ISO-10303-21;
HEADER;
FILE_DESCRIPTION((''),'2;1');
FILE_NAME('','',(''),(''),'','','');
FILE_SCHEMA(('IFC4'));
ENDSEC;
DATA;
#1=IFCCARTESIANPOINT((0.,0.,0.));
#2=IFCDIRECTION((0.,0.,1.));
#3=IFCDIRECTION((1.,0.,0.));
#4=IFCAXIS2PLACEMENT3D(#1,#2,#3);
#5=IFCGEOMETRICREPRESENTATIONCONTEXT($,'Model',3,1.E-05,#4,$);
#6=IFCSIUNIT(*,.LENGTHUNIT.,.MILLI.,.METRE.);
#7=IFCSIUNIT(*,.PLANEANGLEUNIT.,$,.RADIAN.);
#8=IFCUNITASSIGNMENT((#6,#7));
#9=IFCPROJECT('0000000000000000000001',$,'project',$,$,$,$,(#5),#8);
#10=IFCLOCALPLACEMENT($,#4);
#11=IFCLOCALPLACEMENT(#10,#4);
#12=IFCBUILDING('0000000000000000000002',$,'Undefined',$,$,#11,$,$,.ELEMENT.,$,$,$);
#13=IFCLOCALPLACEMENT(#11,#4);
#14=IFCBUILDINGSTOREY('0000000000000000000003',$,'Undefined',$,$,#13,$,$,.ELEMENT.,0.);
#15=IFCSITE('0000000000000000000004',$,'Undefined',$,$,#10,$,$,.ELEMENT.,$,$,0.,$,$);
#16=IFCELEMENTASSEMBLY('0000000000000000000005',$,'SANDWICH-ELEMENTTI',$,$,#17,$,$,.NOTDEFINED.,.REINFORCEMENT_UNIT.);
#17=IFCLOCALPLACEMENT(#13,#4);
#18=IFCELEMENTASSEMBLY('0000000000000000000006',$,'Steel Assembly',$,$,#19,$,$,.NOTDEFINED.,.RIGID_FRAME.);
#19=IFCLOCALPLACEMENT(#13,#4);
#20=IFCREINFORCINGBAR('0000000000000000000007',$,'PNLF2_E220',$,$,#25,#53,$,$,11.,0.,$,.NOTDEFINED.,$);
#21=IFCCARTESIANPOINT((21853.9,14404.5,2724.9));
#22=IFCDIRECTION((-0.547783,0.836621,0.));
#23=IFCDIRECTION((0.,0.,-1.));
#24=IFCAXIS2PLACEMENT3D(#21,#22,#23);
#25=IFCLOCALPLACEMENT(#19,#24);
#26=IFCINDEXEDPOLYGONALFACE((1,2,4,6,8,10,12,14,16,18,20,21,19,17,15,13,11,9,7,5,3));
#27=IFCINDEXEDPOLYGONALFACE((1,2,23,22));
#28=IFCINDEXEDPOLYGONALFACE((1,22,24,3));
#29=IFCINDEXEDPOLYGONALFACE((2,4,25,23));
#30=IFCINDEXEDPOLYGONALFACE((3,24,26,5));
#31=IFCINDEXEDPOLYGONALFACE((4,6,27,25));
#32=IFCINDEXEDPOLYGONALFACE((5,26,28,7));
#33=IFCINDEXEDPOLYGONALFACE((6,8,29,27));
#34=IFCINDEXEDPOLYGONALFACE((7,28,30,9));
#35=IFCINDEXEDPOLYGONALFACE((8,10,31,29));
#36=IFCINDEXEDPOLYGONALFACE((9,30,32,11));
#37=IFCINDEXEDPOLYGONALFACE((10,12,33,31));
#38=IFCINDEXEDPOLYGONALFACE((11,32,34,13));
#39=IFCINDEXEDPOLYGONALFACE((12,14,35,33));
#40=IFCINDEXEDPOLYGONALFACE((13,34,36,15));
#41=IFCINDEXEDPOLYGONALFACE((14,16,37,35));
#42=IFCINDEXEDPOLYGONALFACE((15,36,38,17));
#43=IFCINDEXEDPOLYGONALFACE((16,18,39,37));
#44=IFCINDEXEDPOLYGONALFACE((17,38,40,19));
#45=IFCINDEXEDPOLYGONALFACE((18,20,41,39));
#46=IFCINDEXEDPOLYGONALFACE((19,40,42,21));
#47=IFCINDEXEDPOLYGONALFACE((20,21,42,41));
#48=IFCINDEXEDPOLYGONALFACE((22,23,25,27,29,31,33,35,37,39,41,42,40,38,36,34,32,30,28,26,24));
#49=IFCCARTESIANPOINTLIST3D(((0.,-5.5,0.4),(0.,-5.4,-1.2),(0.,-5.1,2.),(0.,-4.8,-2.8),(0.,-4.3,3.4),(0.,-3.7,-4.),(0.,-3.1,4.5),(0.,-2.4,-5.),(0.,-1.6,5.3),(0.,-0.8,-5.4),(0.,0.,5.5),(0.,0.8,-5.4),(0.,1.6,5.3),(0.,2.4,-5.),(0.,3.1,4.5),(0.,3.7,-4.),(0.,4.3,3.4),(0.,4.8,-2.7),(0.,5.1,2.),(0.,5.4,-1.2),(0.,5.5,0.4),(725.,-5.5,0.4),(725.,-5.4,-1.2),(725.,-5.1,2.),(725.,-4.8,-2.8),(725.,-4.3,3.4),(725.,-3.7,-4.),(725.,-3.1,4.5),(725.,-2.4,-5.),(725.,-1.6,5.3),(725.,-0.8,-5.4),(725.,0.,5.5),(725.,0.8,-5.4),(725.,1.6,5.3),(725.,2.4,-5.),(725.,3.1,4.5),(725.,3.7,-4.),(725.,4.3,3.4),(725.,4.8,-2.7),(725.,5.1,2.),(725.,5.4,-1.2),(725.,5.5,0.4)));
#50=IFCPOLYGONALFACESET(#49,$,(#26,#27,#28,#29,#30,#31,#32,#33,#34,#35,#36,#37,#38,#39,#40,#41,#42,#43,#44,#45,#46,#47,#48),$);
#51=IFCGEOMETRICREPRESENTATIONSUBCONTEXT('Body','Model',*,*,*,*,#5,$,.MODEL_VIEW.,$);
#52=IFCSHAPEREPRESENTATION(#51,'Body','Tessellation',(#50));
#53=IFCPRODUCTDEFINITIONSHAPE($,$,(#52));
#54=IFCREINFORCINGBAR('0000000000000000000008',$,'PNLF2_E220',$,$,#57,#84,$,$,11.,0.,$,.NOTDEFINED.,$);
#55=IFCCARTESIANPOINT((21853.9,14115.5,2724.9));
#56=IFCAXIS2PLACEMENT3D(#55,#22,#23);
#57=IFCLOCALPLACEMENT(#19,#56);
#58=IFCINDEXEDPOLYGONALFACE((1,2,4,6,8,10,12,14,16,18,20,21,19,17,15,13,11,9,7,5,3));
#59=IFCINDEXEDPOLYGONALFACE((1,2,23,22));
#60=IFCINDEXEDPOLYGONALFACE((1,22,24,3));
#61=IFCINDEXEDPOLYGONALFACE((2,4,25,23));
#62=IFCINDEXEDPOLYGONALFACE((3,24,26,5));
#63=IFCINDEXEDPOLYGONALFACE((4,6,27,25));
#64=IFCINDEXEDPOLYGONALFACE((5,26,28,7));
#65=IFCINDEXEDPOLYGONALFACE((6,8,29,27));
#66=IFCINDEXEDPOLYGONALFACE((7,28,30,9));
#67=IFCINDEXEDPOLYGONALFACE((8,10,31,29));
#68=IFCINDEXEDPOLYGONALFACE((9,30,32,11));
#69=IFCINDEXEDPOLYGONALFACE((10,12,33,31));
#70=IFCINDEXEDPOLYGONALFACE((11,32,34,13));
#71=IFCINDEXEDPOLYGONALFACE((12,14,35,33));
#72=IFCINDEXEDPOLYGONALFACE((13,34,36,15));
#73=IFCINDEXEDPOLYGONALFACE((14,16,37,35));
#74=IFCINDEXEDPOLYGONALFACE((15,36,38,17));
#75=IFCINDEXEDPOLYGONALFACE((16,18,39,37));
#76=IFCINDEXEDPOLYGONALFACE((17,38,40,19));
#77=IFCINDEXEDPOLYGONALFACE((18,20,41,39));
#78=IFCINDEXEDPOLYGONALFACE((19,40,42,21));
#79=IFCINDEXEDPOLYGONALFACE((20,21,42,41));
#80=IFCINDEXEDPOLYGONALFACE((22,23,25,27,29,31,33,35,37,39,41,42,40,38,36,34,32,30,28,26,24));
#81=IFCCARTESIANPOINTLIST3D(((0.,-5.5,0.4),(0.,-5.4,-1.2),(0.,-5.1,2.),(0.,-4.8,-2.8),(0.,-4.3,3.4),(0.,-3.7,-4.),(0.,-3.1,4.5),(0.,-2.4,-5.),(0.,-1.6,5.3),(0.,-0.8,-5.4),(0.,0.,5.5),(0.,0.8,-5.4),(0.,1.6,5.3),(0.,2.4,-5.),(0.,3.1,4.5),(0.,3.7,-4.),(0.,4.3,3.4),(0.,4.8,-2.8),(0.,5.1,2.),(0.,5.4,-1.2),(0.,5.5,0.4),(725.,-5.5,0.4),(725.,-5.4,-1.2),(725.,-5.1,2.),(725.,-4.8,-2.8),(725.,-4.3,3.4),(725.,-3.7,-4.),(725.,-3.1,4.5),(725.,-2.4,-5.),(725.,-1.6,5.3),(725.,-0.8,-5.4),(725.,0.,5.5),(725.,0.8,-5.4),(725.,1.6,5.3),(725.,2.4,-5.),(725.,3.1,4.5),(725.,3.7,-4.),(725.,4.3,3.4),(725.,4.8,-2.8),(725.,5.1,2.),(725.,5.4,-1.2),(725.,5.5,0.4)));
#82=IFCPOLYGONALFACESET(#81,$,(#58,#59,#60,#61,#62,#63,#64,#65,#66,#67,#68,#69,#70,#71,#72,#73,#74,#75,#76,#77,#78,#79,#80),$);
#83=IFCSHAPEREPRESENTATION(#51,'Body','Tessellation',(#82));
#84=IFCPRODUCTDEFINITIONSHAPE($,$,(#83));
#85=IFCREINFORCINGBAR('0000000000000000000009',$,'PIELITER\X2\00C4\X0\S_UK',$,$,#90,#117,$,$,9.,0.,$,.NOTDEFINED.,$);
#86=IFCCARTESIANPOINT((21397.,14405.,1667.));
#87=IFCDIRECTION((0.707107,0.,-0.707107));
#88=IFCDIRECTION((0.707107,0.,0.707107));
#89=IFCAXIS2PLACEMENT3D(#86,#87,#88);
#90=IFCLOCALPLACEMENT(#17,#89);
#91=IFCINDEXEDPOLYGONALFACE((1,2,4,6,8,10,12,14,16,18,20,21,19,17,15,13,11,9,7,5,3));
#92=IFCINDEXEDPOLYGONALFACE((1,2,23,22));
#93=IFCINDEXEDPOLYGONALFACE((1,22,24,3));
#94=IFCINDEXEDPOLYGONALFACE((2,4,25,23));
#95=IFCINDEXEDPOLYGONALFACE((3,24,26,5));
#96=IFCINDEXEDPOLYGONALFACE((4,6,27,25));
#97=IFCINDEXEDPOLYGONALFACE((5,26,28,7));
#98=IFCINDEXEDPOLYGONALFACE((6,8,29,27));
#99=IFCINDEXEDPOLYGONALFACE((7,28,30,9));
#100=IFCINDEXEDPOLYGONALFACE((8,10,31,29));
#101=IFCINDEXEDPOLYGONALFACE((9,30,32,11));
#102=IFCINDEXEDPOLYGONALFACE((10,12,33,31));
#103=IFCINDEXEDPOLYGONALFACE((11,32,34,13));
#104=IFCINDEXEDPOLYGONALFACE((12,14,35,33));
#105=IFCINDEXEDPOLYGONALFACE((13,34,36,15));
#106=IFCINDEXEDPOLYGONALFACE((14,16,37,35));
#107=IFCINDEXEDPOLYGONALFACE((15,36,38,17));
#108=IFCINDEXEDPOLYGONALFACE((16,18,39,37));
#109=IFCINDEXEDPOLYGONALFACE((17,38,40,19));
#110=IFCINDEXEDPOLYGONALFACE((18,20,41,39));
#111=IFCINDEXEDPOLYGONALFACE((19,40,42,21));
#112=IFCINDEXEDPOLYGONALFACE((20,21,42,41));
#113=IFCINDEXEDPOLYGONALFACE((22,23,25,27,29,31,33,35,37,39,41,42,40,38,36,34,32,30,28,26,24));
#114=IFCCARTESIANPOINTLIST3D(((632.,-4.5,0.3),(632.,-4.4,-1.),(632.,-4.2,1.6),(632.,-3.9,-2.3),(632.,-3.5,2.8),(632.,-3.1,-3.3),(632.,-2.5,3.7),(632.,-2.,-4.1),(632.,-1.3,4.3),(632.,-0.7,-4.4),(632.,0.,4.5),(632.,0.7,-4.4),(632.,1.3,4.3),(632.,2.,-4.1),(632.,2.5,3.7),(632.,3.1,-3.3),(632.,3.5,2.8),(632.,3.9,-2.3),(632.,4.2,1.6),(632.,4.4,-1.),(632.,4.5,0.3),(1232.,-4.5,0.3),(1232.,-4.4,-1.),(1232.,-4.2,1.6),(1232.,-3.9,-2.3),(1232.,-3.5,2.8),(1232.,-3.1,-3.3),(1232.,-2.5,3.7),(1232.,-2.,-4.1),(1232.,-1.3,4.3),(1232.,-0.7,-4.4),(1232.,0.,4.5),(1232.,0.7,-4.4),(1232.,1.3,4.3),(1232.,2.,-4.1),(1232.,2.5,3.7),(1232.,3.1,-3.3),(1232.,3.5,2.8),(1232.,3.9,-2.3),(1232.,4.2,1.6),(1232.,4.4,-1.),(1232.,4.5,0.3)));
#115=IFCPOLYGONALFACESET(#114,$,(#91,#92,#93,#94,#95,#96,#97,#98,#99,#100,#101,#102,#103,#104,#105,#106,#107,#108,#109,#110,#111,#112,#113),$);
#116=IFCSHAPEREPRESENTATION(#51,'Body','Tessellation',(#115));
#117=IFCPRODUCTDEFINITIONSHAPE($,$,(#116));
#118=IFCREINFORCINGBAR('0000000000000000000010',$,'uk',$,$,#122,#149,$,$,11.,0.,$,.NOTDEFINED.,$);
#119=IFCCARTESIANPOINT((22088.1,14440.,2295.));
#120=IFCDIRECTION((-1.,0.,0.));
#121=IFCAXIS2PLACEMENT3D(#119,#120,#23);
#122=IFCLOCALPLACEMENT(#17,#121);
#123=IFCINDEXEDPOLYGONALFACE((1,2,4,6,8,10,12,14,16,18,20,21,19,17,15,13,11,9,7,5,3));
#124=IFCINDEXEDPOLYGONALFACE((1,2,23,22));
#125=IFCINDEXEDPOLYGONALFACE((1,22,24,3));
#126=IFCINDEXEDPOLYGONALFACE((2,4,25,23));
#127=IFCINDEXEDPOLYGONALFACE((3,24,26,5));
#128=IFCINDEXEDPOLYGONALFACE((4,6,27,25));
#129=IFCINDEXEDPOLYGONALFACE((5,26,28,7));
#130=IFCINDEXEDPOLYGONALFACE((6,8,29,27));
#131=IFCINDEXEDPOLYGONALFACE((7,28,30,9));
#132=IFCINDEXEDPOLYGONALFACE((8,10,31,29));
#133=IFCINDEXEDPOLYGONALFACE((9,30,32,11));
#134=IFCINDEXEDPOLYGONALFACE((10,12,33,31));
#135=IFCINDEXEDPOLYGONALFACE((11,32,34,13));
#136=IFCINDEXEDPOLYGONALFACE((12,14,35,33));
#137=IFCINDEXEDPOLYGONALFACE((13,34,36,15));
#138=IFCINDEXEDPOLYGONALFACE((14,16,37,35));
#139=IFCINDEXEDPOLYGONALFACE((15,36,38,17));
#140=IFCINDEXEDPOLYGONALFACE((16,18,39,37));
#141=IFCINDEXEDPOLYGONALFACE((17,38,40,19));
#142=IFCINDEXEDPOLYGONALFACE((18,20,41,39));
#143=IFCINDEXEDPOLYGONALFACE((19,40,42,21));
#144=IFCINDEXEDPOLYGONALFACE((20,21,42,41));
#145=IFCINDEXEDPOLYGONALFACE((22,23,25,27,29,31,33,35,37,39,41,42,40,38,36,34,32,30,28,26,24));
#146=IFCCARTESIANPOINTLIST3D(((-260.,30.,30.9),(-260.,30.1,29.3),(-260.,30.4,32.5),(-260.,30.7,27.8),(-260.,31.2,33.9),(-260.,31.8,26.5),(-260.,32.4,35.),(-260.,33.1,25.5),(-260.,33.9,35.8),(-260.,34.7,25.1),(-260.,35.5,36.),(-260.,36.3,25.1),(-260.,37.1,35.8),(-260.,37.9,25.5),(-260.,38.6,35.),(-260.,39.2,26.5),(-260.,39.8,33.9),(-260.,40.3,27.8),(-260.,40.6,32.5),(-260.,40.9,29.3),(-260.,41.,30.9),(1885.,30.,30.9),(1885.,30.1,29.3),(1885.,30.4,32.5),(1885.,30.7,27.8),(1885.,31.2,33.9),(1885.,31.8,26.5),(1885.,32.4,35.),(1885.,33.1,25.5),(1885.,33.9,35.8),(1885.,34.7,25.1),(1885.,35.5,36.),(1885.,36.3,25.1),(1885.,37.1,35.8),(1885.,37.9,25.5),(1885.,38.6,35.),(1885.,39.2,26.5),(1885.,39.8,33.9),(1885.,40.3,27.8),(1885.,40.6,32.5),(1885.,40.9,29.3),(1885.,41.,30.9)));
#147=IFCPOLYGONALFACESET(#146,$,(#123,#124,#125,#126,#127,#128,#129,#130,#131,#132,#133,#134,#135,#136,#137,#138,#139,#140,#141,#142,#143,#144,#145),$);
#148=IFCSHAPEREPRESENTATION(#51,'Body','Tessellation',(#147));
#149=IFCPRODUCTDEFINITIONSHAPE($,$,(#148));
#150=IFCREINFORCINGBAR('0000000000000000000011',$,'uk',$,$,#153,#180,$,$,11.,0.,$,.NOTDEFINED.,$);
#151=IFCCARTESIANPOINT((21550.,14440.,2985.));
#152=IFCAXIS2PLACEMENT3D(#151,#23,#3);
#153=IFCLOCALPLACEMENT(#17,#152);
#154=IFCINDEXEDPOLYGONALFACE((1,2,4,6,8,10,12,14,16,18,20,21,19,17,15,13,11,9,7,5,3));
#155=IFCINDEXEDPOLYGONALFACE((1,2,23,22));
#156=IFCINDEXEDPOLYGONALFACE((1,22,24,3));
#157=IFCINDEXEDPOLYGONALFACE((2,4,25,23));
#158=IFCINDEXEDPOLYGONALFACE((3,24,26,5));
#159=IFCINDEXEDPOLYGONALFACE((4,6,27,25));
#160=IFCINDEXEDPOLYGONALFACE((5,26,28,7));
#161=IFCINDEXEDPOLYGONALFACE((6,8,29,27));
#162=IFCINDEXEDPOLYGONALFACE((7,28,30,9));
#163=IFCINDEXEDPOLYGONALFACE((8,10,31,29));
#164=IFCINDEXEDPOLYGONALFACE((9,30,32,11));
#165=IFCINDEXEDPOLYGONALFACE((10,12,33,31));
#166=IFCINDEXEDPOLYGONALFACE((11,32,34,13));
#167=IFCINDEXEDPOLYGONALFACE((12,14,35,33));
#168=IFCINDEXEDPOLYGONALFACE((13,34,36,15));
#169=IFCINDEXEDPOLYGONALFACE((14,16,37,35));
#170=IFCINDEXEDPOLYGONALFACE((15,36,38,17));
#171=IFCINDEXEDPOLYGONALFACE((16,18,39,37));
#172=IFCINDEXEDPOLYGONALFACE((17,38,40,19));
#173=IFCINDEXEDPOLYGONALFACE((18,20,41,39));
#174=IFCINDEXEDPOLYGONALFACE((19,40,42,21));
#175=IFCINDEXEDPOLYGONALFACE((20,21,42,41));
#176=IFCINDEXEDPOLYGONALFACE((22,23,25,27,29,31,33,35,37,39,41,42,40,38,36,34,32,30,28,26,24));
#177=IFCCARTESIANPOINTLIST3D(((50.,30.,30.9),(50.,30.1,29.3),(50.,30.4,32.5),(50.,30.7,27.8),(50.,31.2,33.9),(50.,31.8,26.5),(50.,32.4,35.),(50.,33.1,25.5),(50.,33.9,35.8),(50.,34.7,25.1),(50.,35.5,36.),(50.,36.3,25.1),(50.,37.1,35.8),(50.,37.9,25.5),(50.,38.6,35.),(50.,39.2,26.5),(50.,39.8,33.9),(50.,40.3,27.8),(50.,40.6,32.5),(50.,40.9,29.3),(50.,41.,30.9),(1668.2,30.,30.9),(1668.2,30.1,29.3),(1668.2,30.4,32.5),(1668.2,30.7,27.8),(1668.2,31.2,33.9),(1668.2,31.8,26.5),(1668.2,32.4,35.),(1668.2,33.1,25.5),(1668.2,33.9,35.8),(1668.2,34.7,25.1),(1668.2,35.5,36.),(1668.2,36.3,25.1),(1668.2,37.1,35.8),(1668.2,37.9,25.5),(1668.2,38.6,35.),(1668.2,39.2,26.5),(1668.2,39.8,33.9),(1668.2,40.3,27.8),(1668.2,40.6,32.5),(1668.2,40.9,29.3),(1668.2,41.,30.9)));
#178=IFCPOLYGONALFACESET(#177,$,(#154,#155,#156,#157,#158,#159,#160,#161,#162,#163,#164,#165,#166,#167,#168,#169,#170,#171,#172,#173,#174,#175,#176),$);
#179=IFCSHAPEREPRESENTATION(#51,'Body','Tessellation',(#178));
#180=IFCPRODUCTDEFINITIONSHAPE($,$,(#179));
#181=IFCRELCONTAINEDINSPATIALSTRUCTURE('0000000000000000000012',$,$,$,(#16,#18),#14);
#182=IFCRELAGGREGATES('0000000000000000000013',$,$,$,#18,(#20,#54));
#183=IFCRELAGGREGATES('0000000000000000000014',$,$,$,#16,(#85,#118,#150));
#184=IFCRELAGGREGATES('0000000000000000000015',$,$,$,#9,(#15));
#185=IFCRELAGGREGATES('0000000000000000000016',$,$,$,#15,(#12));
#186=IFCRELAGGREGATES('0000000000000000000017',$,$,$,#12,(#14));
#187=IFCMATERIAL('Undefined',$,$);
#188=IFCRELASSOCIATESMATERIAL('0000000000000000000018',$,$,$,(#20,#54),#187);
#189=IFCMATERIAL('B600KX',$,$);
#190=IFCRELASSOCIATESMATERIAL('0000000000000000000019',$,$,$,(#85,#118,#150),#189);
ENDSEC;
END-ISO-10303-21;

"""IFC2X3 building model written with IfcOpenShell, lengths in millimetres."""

from ifc_helpers import new_model, entity, si_unit, frame, origin_with_axes, place, context, subcontext, project, spatial, source, transform, mapped, material, element, aggregate, save


model = new_model("IFC2X3")

# Units and contexts
model_context = context("Model", 3, precision=1e-05, world=origin_with_axes())
body_context = subcontext(model_context, "Body", "Model", "MODEL_VIEW")
ifc_project = project(units=[si_unit("LENGTHUNIT", "METRE", prefix="MILLI"), si_unit("PLANEANGLEUNIT", "RADIAN")], contexts=[model_context])

# Site, building, storey
site_placement = place(None, origin_with_axes())
site = spatial("IfcSite", under=ifc_project, at=site_placement, Name="Undefined", CompositionType="ELEMENT", RefElevation=0.0)
building_placement = place(site_placement, origin_with_axes())
building = spatial("IfcBuilding", under=site, at=building_placement, Name="Undefined", CompositionType="ELEMENT")
storey_placement = place(building_placement, origin_with_axes())
storey = spatial("IfcBuildingStorey", under=building, at=storey_placement, Name="Undefined", CompositionType="ELEMENT", Elevation=0.0)

# Element assembly
assembly_1_placement = place(storey_placement, origin_with_axes())
assembly_1 = element("IfcElementAssembly", 1, at=assembly_1_placement, inside=storey, Name="SANDWICH-ELEMENTTI", AssemblyPlace="NOTDEFINED", PredefinedType="REINFORCEMENT_UNIT")

# Element assembly, reinforcing bars
assembly_2_placement = place(storey_placement, origin_with_axes())
assembly_2 = element("IfcElementAssembly", 2, at=assembly_2_placement, inside=storey, Name="Steel Assembly", AssemblyPlace="NOTDEFINED", PredefinedType="RIGID_FRAME")
ifc_material_1 = material(Name="Undefined")
shared_shape_1 = source(origin_with_axes(), body_context, "Body", "AdvancedSweptSolid", [
    entity("IfcSweptDiskSolid", entity("IfcTrimmedCurve", entity("IfcLine", entity("IfcCartesianPoint", [0.0, 0.0, 0.0]), entity("IfcVector", entity("IfcDirection", [1.0, 0.0, 0.0]), 1.0)), [entity("IfcParameterValue", 0.0)], [entity("IfcParameterValue", 725.0)], True, "PARAMETER"), 5.5, None, 0.0, 725.0),
])
reinforcing_bar_1_placement = place(assembly_2_placement, frame((21853.9, 14404.5, 2724.9), z_axis=(-0.547783, 0.836621, 0.0), x_axis=(0.0, 0.0, -1.0)))
reinforcing_bar_1 = element("IfcReinforcingBar", 3, at=reinforcing_bar_1_placement, material=ifc_material_1, Name="PNLF2_E220", BarRole="NOTDEFINED", CrossSectionArea=0.0, NominalDiameter=11.0, context=body_context, shape_type="MappedRepresentation", body=[
    mapped(shared_shape_1, transform((0.0, 0.0, 0.0))),
])
shared_shape_2 = source(origin_with_axes(), body_context, "Body", "AdvancedSweptSolid", [
    entity("IfcSweptDiskSolid", entity("IfcTrimmedCurve", entity("IfcLine", entity("IfcCartesianPoint", [0.0, 0.0, 0.0]), entity("IfcVector", entity("IfcDirection", [1.0, 0.0, 0.0]), 1.0)), [entity("IfcParameterValue", 0.0)], [entity("IfcParameterValue", 725.0)], True, "PARAMETER"), 5.5, None, 0.0, 725.0),
])
reinforcing_bar_2_placement = place(assembly_2_placement, frame((21853.9, 14115.5, 2724.9), z_axis=(-0.547783, 0.836621, 0.0), x_axis=(0.0, 0.0, -1.0)))
reinforcing_bar_2 = element("IfcReinforcingBar", 4, at=reinforcing_bar_2_placement, material=ifc_material_1, Name="PNLF2_E220", BarRole="NOTDEFINED", CrossSectionArea=0.0, NominalDiameter=11.0, context=body_context, shape_type="MappedRepresentation", body=[
    mapped(shared_shape_2, transform((0.0, 0.0, 0.0))),
])
aggregate(assembly_2, [reinforcing_bar_1, reinforcing_bar_2])

# Reinforcing bars
ifc_material_2 = material(Name="B600KX")
shared_shape_3 = source(origin_with_axes(), body_context, "Body", "AdvancedSweptSolid", [
    entity("IfcSweptDiskSolid", entity("IfcTrimmedCurve", entity("IfcLine", entity("IfcCartesianPoint", [0.0, 0.0, 0.0]), entity("IfcVector", entity("IfcDirection", [1.0, 0.0, 0.0]), 1.0)), [entity("IfcParameterValue", 0.0)], [entity("IfcParameterValue", 600.0)], True, "PARAMETER"), 4.5, None, 0.0, 600.0),
])
reinforcing_bar_3_placement = place(assembly_1_placement, frame((21397.0, 14405.0, 1667.0), z_axis=(0.707107, 0.0, -0.707107), x_axis=(0.707107, 0.0, 0.707107)))
reinforcing_bar_3 = element("IfcReinforcingBar", 5, at=reinforcing_bar_3_placement, material=ifc_material_2, Name="PIELITERÄS_UK", BarRole="NOTDEFINED", CrossSectionArea=0.0, NominalDiameter=9.0, context=body_context, shape_type="MappedRepresentation", body=[
    mapped(shared_shape_3, transform((632.0, 0.0, 0.0))),
])
shared_shape_4 = source(origin_with_axes(), body_context, "Body", "AdvancedSweptSolid", [
    entity("IfcSweptDiskSolid", entity("IfcTrimmedCurve", entity("IfcLine", entity("IfcCartesianPoint", [0.0, 0.0, 0.0]), entity("IfcVector", entity("IfcDirection", [1.0, 0.0, 0.0]), 1.0)), [entity("IfcParameterValue", 0.0)], [entity("IfcParameterValue", 2144.9998)], True, "PARAMETER"), 5.5, None, 0.0, 2145.0),
])
reinforcing_bar_4_placement = place(assembly_1_placement, frame((22088.1, 14440.0, 2295.0), z_axis=(-1.0, 0.0, 0.0), x_axis=(0.0, 0.0, -1.0)))
reinforcing_bar_4 = element("IfcReinforcingBar", 6, at=reinforcing_bar_4_placement, material=ifc_material_2, Name="uk", BarRole="NOTDEFINED", CrossSectionArea=0.0, NominalDiameter=11.0, context=body_context, shape_type="MappedRepresentation", body=[
    mapped(shared_shape_4, transform((-260.0, 35.5, 30.5))),
])
shared_shape_5 = source(origin_with_axes(), body_context, "Body", "AdvancedSweptSolid", [
    entity("IfcSweptDiskSolid", entity("IfcTrimmedCurve", entity("IfcLine", entity("IfcCartesianPoint", [0.0, 0.0, 0.0]), entity("IfcVector", entity("IfcDirection", [1.0, 0.0, 0.0]), 1.0)), [entity("IfcParameterValue", 0.0)], [entity("IfcParameterValue", 1618.1602)], True, "PARAMETER"), 5.5, None, 0.0, 1618.2),
])
reinforcing_bar_5_placement = place(assembly_1_placement, frame((21550.0, 14440.0, 2985.0), z_axis=(0.0, 0.0, -1.0), x_axis=(1.0, 0.0, 0.0)))
reinforcing_bar_5 = element("IfcReinforcingBar", 7, at=reinforcing_bar_5_placement, material=ifc_material_2, Name="uk", BarRole="NOTDEFINED", CrossSectionArea=0.0, NominalDiameter=11.0, context=body_context, shape_type="MappedRepresentation", body=[
    mapped(shared_shape_5, transform((50.0, 35.5, 30.5))),
])
aggregate(assembly_1, [reinforcing_bar_3, reinforcing_bar_4, reinforcing_bar_5])

save(model, "model.ifc")
